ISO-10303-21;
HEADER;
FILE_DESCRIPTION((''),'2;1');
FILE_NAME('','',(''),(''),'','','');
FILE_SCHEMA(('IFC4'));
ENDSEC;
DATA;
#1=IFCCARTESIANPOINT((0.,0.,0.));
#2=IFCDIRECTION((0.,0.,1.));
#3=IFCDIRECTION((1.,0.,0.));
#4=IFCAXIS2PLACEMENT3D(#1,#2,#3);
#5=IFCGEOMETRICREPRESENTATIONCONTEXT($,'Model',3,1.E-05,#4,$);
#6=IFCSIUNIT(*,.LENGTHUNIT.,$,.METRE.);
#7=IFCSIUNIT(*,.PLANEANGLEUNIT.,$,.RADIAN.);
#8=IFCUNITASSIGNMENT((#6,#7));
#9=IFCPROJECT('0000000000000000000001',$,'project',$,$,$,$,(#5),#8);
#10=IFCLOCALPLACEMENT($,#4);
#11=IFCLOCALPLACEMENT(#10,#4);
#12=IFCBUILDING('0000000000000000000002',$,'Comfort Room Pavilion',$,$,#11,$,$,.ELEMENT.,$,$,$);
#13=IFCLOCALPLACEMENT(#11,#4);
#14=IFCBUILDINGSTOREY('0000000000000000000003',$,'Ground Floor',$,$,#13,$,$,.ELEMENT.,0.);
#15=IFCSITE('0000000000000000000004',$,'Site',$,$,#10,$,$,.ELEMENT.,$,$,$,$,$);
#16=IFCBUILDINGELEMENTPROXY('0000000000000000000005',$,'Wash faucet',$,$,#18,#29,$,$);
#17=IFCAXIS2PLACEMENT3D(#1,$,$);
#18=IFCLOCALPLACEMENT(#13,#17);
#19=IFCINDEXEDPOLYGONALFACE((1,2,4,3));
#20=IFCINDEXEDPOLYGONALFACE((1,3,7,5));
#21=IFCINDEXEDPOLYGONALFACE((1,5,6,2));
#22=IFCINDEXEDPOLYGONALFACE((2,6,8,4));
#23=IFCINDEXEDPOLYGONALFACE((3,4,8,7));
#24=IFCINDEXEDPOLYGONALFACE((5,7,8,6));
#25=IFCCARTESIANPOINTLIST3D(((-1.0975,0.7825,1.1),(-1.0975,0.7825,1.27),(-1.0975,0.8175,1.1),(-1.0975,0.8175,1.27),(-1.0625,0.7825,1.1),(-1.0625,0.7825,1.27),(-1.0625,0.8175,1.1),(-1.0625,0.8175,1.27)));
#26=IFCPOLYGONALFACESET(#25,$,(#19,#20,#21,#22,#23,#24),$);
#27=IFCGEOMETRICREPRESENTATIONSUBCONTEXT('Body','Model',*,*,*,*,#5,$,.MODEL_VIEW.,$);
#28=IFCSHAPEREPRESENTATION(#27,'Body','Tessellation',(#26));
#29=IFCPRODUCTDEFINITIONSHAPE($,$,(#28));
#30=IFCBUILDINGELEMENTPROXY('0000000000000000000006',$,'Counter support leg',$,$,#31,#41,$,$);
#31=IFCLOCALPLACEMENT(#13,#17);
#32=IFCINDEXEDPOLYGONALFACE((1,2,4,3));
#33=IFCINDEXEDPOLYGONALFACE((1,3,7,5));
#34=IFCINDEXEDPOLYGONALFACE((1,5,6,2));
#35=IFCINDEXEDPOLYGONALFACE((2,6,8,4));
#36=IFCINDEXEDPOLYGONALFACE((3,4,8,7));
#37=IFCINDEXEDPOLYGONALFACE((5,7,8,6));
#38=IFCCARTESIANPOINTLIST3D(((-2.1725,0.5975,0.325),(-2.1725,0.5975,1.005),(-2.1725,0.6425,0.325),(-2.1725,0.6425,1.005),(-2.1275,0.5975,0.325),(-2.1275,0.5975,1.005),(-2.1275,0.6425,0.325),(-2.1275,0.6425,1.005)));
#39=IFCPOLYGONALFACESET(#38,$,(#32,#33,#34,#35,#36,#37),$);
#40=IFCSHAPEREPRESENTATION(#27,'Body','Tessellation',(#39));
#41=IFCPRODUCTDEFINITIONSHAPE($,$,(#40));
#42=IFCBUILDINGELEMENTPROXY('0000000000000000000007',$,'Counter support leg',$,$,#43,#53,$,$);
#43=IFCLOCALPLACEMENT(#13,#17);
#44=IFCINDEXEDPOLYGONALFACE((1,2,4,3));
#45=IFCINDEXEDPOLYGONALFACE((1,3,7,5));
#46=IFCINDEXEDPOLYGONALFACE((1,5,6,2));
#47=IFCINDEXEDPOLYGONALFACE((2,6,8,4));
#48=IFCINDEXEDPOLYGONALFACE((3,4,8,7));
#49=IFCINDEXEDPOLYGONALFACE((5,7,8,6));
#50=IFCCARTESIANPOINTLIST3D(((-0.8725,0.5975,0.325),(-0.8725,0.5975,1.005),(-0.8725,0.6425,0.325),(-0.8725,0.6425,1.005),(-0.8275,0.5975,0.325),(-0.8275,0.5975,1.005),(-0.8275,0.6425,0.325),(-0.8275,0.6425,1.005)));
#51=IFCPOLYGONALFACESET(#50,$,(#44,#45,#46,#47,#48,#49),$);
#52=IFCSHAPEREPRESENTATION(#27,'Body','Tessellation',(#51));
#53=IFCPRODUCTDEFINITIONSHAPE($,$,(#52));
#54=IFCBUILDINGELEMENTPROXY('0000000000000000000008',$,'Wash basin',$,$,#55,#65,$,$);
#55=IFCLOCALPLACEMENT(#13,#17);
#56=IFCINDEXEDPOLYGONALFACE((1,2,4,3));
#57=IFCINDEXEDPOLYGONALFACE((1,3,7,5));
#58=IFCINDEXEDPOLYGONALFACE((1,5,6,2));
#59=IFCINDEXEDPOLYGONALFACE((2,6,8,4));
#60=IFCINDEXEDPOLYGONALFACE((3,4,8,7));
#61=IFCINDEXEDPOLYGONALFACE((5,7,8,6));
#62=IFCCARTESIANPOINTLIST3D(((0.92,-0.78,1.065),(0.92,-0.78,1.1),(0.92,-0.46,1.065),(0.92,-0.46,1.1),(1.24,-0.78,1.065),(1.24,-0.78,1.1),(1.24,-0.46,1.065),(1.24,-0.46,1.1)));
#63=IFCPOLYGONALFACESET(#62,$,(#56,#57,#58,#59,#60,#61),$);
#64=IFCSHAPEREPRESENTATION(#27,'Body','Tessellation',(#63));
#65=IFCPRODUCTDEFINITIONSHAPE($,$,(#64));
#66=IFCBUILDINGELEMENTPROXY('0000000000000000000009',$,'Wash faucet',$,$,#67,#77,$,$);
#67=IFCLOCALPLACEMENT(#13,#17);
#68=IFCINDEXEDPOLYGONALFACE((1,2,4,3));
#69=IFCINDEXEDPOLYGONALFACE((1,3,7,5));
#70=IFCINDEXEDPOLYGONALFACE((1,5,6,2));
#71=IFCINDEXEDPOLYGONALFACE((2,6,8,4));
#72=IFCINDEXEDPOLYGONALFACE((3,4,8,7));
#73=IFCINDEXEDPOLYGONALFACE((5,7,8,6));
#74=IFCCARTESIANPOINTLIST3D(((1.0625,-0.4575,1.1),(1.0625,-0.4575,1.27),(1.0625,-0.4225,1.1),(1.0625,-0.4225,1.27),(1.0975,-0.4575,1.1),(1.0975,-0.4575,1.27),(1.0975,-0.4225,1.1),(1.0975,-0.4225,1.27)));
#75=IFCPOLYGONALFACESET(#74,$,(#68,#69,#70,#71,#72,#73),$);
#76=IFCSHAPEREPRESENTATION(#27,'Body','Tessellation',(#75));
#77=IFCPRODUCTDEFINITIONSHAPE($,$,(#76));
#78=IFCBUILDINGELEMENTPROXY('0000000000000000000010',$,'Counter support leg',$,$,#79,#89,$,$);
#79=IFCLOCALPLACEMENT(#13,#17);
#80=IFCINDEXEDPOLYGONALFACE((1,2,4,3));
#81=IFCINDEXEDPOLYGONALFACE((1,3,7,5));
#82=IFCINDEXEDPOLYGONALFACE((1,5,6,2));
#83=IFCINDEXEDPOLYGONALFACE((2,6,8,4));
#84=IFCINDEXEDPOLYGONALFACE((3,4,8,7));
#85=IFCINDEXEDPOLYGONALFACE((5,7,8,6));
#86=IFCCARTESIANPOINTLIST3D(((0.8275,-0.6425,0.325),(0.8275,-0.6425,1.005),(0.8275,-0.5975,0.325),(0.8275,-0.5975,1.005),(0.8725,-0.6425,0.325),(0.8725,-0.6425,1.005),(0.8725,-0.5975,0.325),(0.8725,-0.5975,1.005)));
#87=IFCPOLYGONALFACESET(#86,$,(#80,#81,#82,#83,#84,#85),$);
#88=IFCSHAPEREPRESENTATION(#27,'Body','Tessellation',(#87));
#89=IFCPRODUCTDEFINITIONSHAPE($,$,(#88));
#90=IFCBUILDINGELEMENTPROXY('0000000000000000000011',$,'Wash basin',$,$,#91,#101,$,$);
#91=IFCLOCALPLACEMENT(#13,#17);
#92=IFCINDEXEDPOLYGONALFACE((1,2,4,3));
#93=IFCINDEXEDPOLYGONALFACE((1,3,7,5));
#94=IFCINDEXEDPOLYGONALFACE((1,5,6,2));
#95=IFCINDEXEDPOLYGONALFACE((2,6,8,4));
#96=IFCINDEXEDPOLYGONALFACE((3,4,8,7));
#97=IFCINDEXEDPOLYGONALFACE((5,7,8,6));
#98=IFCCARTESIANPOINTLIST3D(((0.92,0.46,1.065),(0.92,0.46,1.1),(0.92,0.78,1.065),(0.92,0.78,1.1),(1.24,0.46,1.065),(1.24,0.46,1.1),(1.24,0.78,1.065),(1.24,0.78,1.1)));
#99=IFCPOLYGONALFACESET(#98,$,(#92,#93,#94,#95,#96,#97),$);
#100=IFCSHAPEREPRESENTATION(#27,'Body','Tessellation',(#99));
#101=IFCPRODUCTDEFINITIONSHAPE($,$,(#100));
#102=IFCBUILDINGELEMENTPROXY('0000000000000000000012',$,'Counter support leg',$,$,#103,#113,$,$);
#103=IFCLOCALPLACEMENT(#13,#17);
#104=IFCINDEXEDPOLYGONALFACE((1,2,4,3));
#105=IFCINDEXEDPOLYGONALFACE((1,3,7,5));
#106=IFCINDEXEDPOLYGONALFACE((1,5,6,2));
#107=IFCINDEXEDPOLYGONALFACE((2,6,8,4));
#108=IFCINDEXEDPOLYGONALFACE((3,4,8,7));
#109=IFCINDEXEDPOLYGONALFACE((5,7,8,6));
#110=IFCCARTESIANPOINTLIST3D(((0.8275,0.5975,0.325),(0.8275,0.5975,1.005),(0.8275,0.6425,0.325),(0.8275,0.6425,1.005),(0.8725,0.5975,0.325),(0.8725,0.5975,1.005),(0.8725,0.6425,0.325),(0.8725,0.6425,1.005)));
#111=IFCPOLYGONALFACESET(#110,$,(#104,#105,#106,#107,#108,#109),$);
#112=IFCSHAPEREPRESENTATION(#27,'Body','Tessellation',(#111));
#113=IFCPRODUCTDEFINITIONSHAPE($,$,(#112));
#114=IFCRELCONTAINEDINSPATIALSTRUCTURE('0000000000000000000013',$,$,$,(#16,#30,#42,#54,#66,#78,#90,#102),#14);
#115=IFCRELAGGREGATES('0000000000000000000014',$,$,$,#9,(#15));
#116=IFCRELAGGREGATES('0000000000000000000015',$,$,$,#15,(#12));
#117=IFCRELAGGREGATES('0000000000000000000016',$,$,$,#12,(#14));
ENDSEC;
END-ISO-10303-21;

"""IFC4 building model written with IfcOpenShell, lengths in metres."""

from ifc_helpers import new_model, si_unit, frame, origin_with_axes, origin_2d, place, context, subcontext, project, spatial, rectangle, extrude, element, save


model = new_model("IFC4")

# Units and contexts
model_context = context("Model", 3, precision=1e-05, world=origin_with_axes())
body_context = subcontext(model_context, "Body", "Model", "MODEL_VIEW")
ifc_project = project(units=[si_unit("LENGTHUNIT", "METRE"), si_unit("PLANEANGLEUNIT", "RADIAN")], contexts=[model_context])

# Site, building, storey
site_placement = place(None, origin_with_axes())
site = spatial("IfcSite", under=ifc_project, at=site_placement, Name="Site", CompositionType="ELEMENT")
building_placement = place(site_placement, origin_with_axes())
building = spatial("IfcBuilding", under=site, at=building_placement, Name="Comfort Room Pavilion", CompositionType="ELEMENT")
storey_placement = place(building_placement, origin_with_axes())
storey = spatial("IfcBuildingStorey", under=building, at=storey_placement, Name="Ground Floor", CompositionType="ELEMENT", Elevation=0.0)

# Building element proxies
proxy_1_placement = place(storey_placement, frame((-1.08, 0.8, 1.1), z_axis=(0.0, 0.0, 1.0), x_axis=(1.0, 0.0, 0.0)))
element("IfcBuildingElementProxy", 1, at=proxy_1_placement, inside=storey, Name="Wash faucet", context=body_context, shape_type="SweptSolid", body=[
    extrude(rectangle(XDim=0.035, YDim=0.035, at=origin_2d()), origin_with_axes(), (0.0, 0.0, 1.0), 0.17),
])
for number, where, z_axis, x_axis, name in (
    (2, (-2.15, 0.62, 0.325), (0.0, 0.0, 1.0), (1.0, 0.0, 0.0), "Counter support leg"),
    (3, (-0.85, 0.62, 0.325), (0.0, 0.0, 1.0), (1.0, 0.0, 0.0), "Counter support leg"),
):
    element("IfcBuildingElementProxy", number, at=place(storey_placement, frame(where, z_axis=z_axis, x_axis=x_axis)), inside=storey, Name=name, context=body_context, shape_type="SweptSolid", body=[
        extrude(rectangle(XDim=0.045, YDim=0.045, at=origin_2d()), origin_with_axes(), (0.0, 0.0, 1.0), 0.68),
    ])
proxy_2_placement = place(storey_placement, frame((1.08, -0.62, 1.065), z_axis=(0.0, 0.0, 1.0), x_axis=(1.0, 0.0, 0.0)))
element("IfcBuildingElementProxy", 4, at=proxy_2_placement, inside=storey, Name="Wash basin", context=body_context, shape_type="SweptSolid", body=[
    extrude(rectangle(XDim=0.32, YDim=0.32, at=origin_2d()), origin_with_axes(), (0.0, 0.0, 1.0), 0.035),
])
proxy_3_placement = place(storey_placement, frame((1.08, -0.44, 1.1), z_axis=(0.0, 0.0, 1.0), x_axis=(1.0, 0.0, 0.0)))
element("IfcBuildingElementProxy", 5, at=proxy_3_placement, inside=storey, Name="Wash faucet", context=body_context, shape_type="SweptSolid", body=[
    extrude(rectangle(XDim=0.035, YDim=0.035, at=origin_2d()), origin_with_axes(), (0.0, 0.0, 1.0), 0.17),
])
proxy_4_placement = place(storey_placement, frame((0.85, -0.62, 0.325), z_axis=(0.0, 0.0, 1.0), x_axis=(1.0, 0.0, 0.0)))
element("IfcBuildingElementProxy", 6, at=proxy_4_placement, inside=storey, Name="Counter support leg", context=body_context, shape_type="SweptSolid", body=[
    extrude(rectangle(XDim=0.045, YDim=0.045, at=origin_2d()), origin_with_axes(), (0.0, 0.0, 1.0), 0.68),
])
proxy_5_placement = place(storey_placement, frame((1.08, 0.62, 1.065), z_axis=(0.0, 0.0, 1.0), x_axis=(1.0, 0.0, 0.0)))
element("IfcBuildingElementProxy", 7, at=proxy_5_placement, inside=storey, Name="Wash basin", context=body_context, shape_type="SweptSolid", body=[
    extrude(rectangle(XDim=0.32, YDim=0.32, at=origin_2d()), origin_with_axes(), (0.0, 0.0, 1.0), 0.035),
])
proxy_6_placement = place(storey_placement, frame((0.85, 0.62, 0.325), z_axis=(0.0, 0.0, 1.0), x_axis=(1.0, 0.0, 0.0)))
element("IfcBuildingElementProxy", 8, at=proxy_6_placement, inside=storey, Name="Counter support leg", context=body_context, shape_type="SweptSolid", body=[
    extrude(rectangle(XDim=0.045, YDim=0.045, at=origin_2d()), origin_with_axes(), (0.0, 0.0, 1.0), 0.68),
])

save(model, "model.ifc")
